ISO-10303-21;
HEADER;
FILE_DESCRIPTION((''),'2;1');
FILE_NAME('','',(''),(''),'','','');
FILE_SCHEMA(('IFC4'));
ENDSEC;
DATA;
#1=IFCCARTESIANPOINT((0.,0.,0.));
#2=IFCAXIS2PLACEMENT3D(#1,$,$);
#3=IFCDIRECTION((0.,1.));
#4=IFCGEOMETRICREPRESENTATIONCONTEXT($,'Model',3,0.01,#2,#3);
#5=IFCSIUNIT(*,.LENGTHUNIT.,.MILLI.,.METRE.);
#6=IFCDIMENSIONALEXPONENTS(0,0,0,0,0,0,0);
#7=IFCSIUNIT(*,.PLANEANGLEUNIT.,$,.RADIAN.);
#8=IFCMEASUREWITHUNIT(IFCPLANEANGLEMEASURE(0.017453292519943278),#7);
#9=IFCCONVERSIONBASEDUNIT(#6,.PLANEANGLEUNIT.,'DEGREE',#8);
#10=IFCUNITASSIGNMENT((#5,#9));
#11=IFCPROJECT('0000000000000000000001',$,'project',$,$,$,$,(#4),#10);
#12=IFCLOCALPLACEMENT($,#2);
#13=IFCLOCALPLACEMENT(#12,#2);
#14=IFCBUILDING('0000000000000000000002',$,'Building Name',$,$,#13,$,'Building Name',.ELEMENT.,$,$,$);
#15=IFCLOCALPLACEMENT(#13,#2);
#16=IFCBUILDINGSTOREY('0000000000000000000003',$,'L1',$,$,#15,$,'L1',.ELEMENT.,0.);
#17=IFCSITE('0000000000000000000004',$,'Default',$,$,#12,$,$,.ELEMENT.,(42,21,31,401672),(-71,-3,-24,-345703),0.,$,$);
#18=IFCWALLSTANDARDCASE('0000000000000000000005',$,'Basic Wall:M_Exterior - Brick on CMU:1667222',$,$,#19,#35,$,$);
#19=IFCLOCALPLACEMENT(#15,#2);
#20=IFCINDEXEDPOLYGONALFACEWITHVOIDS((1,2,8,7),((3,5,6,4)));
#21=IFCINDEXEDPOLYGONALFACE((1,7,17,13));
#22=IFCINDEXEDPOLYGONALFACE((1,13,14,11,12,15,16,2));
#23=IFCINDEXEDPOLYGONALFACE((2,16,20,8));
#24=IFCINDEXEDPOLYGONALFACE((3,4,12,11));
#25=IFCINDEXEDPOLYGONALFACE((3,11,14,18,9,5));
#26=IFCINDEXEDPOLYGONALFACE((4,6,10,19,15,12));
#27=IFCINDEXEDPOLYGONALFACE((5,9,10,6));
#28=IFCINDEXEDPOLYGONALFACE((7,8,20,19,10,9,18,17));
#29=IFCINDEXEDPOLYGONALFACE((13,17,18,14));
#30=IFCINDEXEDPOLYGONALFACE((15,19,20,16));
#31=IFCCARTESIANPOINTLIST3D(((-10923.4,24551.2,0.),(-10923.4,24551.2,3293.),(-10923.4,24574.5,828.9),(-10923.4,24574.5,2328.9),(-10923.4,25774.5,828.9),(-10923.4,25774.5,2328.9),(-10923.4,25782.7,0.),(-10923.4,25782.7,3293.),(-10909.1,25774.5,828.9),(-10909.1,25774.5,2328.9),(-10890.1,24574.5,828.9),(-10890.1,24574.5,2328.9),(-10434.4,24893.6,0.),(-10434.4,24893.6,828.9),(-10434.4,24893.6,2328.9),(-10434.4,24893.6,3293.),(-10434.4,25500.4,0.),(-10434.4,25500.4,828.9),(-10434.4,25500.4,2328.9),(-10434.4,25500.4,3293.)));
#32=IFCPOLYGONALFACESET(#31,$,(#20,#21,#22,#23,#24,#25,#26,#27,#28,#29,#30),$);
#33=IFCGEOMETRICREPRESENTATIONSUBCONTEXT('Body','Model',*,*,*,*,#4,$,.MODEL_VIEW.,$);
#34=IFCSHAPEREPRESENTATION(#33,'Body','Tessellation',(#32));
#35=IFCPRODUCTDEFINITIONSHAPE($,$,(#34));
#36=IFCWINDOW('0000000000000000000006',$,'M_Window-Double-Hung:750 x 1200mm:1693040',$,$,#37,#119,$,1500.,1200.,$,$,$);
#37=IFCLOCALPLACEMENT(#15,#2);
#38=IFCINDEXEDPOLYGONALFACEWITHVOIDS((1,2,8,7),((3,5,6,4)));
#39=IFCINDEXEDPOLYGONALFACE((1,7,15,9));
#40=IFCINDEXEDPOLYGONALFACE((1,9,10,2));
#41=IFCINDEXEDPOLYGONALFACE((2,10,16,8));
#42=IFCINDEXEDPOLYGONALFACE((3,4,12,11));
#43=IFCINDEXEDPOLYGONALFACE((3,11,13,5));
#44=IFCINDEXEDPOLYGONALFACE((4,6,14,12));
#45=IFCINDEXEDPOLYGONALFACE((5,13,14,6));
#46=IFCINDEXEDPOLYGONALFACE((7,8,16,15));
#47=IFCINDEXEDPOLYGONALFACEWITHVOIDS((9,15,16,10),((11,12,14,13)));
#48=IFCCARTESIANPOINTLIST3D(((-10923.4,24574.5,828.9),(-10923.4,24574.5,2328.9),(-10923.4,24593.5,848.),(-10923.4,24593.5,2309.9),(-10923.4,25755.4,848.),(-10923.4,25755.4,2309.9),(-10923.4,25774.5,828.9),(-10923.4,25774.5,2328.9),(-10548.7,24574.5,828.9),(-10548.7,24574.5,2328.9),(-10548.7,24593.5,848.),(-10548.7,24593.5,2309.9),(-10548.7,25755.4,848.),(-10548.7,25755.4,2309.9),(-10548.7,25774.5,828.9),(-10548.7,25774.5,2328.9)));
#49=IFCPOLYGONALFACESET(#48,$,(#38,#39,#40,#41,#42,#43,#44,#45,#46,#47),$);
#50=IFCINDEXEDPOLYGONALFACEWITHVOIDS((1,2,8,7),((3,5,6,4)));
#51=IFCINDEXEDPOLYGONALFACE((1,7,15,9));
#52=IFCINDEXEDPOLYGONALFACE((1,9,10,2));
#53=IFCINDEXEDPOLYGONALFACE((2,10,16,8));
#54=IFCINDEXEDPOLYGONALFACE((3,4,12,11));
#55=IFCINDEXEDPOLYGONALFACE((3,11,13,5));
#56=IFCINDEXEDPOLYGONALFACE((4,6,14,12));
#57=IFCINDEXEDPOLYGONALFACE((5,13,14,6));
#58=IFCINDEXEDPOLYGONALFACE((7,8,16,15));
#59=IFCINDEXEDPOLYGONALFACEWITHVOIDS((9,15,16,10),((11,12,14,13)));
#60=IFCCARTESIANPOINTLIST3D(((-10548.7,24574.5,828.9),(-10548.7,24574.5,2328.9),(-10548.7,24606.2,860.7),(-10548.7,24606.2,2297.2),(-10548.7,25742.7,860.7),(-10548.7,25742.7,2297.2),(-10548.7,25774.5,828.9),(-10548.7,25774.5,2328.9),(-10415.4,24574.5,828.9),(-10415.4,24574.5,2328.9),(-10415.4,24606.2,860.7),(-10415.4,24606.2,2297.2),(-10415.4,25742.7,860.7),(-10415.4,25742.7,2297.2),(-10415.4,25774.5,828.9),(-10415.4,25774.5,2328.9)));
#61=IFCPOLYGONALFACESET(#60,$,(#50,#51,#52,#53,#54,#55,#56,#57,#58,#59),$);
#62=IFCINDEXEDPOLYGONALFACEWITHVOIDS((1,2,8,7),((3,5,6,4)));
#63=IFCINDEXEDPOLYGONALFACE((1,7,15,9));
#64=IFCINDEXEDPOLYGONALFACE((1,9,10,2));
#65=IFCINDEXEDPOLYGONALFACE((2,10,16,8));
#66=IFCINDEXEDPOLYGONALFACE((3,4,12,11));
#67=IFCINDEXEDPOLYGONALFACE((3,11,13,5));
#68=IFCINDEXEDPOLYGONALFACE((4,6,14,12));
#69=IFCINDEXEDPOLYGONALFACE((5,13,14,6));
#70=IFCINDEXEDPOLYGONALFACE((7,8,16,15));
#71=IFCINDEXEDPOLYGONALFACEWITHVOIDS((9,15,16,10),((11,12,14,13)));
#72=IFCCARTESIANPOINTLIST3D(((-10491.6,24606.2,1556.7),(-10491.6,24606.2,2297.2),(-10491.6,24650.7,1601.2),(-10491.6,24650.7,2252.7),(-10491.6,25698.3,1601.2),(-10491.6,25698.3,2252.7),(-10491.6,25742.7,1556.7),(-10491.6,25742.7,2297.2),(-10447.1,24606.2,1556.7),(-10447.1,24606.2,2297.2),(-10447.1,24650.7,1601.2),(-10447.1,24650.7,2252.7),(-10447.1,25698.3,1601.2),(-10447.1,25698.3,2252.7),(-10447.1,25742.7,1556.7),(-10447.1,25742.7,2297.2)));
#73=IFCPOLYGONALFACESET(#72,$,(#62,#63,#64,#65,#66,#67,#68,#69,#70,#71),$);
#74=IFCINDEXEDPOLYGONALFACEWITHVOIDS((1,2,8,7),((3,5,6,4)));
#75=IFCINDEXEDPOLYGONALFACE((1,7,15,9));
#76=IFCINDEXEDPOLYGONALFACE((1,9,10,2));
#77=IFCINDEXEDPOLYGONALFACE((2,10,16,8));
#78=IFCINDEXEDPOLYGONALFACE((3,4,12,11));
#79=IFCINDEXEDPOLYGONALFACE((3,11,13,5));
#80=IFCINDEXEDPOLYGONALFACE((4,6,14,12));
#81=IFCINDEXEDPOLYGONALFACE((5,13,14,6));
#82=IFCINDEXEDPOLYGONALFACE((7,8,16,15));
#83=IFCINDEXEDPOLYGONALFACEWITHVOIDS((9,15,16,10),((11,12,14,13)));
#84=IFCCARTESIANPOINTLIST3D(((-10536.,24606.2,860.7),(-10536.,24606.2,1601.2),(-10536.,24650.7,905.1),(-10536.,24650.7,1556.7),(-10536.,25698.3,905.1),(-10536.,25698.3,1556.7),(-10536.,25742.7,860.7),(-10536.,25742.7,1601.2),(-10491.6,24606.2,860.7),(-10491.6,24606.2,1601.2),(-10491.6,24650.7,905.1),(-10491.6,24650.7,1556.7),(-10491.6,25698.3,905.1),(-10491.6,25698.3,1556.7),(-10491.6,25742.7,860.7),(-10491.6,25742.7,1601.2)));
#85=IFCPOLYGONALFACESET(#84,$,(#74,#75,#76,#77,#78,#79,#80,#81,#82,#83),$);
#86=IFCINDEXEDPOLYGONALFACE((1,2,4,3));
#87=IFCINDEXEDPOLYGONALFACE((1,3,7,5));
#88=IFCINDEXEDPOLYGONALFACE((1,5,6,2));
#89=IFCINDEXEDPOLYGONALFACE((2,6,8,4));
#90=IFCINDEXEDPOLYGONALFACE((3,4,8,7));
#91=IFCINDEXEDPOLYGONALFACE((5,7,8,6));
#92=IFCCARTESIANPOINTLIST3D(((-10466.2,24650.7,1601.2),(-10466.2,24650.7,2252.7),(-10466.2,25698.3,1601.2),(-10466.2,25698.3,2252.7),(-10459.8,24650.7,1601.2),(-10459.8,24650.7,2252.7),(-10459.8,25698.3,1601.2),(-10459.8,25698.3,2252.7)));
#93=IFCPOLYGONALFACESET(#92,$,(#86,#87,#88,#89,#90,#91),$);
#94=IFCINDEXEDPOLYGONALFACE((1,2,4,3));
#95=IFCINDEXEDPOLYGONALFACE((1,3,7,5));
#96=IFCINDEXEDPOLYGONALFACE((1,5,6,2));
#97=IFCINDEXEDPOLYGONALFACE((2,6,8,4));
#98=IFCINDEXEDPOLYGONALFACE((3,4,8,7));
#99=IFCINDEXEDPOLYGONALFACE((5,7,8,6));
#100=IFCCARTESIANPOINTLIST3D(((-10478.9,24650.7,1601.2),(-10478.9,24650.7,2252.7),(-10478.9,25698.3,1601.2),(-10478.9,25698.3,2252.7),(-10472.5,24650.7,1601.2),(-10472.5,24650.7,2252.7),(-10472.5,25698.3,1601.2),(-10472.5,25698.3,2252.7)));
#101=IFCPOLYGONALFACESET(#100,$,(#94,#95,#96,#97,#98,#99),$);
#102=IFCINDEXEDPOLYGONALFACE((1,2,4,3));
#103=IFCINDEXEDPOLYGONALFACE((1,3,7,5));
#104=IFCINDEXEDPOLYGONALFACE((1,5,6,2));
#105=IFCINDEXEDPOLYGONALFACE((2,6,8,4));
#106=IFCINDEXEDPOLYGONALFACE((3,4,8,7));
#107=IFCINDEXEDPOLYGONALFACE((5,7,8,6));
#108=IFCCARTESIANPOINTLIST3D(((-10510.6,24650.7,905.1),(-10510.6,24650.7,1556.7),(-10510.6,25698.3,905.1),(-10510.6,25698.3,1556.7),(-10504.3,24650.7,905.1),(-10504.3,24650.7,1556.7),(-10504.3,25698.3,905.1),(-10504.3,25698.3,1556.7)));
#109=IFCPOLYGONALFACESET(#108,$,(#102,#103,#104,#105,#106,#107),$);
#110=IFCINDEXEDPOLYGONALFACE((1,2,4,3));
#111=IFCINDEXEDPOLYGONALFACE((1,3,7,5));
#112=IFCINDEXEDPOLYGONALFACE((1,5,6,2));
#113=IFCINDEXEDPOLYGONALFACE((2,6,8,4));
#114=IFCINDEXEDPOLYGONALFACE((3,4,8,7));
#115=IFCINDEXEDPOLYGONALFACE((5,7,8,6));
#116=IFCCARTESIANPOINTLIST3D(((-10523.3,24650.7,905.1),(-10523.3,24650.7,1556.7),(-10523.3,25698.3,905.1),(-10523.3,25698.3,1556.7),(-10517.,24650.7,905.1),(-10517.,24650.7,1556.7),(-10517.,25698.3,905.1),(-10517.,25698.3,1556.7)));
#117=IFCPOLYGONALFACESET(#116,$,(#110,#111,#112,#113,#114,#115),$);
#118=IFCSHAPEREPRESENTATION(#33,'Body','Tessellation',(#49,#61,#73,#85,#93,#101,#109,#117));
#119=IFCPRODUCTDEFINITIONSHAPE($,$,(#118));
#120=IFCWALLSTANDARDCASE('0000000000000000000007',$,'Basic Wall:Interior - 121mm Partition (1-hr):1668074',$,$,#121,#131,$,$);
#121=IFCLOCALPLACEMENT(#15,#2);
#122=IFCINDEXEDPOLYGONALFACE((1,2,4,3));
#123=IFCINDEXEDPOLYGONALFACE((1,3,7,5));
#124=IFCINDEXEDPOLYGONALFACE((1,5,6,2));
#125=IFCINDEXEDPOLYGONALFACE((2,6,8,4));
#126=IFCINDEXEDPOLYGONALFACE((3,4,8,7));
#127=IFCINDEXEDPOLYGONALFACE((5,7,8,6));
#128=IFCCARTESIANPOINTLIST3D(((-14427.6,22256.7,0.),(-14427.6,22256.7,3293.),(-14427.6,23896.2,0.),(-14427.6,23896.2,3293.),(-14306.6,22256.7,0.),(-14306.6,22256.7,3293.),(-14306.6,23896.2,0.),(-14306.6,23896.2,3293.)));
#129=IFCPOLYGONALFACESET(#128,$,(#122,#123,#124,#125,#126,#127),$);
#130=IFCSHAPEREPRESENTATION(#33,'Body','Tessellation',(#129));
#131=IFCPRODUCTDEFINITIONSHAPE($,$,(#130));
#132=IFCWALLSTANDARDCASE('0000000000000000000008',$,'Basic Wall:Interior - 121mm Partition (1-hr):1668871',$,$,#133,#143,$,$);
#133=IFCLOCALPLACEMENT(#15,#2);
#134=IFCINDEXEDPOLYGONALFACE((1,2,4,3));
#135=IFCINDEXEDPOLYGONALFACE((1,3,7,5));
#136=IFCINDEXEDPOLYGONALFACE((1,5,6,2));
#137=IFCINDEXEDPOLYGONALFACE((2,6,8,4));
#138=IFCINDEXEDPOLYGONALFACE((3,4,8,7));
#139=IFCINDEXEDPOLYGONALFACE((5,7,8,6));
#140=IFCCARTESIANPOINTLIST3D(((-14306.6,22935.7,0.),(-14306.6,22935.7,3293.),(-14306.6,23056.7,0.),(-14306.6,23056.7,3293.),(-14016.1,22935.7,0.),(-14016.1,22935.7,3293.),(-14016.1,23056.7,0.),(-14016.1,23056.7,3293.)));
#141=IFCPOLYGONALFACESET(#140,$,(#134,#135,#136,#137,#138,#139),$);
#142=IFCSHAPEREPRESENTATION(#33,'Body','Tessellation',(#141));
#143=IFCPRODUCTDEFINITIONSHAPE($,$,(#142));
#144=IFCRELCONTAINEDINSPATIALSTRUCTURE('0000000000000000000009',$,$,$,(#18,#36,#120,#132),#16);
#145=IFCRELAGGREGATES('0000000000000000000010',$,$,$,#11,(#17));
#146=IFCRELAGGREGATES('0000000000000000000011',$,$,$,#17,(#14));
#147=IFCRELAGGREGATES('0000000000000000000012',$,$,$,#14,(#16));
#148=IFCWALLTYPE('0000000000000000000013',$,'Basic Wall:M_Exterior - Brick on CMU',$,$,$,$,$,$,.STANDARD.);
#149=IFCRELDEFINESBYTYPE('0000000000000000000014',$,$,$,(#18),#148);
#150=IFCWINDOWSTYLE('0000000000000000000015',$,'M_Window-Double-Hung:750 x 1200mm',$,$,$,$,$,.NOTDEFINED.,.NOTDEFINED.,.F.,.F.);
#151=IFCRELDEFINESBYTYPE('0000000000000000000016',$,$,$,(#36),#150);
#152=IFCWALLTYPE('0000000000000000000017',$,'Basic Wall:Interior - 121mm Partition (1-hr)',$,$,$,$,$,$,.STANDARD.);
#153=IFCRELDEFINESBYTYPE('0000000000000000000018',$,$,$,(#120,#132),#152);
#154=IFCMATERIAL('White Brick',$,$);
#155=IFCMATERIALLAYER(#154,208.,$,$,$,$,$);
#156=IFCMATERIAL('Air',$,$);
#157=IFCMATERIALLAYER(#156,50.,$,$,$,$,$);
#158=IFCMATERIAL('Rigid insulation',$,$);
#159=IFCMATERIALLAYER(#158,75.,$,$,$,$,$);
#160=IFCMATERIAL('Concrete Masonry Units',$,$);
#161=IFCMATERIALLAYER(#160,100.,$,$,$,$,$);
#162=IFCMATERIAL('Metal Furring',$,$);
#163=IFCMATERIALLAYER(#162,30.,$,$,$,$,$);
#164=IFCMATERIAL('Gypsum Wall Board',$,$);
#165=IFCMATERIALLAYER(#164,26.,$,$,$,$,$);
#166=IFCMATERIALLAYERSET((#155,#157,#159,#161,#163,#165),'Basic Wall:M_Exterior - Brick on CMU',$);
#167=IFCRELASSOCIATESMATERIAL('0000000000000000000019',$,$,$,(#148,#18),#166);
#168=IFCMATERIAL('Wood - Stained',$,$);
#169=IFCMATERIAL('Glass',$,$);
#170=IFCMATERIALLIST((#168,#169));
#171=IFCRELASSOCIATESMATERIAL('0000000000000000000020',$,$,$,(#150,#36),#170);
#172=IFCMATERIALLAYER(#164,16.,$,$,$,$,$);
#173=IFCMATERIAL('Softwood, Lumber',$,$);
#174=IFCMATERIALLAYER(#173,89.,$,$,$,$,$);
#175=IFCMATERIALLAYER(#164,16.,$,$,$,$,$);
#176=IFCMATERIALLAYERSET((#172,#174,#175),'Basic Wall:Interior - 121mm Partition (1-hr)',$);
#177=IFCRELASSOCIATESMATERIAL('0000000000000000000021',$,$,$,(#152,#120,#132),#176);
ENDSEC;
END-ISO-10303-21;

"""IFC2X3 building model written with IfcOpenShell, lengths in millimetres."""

from ifc_helpers import new_model, entity, si_unit, converted_unit, direction, frame, frame_2d, origin, place, context, subcontext, project, spatial, polyline, rectangle, outline, extrude, clip, bounded_halfspace, source, transform, mapped, material, material_list, layer, layer_set, layer_usage, type_object, type_shapes, element, fill, save


model = new_model("IFC2X3")

# Units and contexts
model_context = context("Model", 3, precision=0.01, world=origin(), true_north=direction((0.0, 1.0)))
body_context = subcontext(model_context, "Body", "Model", "MODEL_VIEW")
ifc_project = project(units=[si_unit("LENGTHUNIT", "METRE", prefix="MILLI"), converted_unit("PLANEANGLEUNIT", "DEGREE", entity("IfcPlaneAngleMeasure", 0.017453292519943278), si_unit("PLANEANGLEUNIT", "RADIAN"), dimensions=[0, 0, 0, 0, 0, 0, 0])], contexts=[model_context])

# Site, building, storey
site_placement = place(None, origin())
site = spatial("IfcSite", under=ifc_project, at=site_placement, Name="Default", CompositionType="ELEMENT", RefLatitude=(42, 21, 31, 401672), RefLongitude=(-71, -3, -24, -345703), RefElevation=0.0)
building_placement = place(site_placement, origin())
building = spatial("IfcBuilding", under=site, at=building_placement, Name="Building Name", LongName="Building Name", CompositionType="ELEMENT")
storey_placement = place(building_placement, origin())
storey = spatial("IfcBuildingStorey", under=building, at=storey_placement, Name="L1", LongName="L1", CompositionType="ELEMENT", Elevation=0.0)

# Shared definitions
ifc_material_1 = material(Name="White Brick")
ifc_layer_1 = layer(ifc_material_1, 208.0)
ifc_material_2 = material(Name="Air")
ifc_layer_2 = layer(ifc_material_2, 50.0)
ifc_material_3 = material(Name="Rigid insulation")
ifc_layer_3 = layer(ifc_material_3, 75.0)
ifc_material_4 = material(Name="Concrete Masonry Units")
ifc_layer_4 = layer(ifc_material_4, 100.0)
ifc_material_5 = material(Name="Metal Furring")
ifc_layer_5 = layer(ifc_material_5, 30.0)
ifc_material_6 = material(Name="Gypsum Wall Board")
ifc_layer_6 = layer(ifc_material_6, 26.0)
ifc_layer_set_1 = layer_set([ifc_layer_1, ifc_layer_2, ifc_layer_3, ifc_layer_4, ifc_layer_5, ifc_layer_6], Name="Basic Wall:M_Exterior - Brick on CMU")
wall_type_1 = type_object("IfcWallType", Name="Basic Wall:M_Exterior - Brick on CMU", PredefinedType="STANDARD", material=ifc_layer_set_1)
ifc_material_7 = material(Name="Wood - Stained")
ifc_material_8 = material(Name="Glass")
ifc_material_list_1 = material_list([ifc_material_7, ifc_material_8])

# Wall, opening, window
ifc_layer_usage_1 = layer_usage(ifc_layer_set_1, "AXIS2", "POSITIVE", -244.5)
wall_1_placement = place(storey_placement, frame((-10678.9, 24551.2, 0.0), z_axis=(0.0, 0.0, 1.0), x_axis=(0.0, 1.0, 0.0)))
wall_1 = element("IfcWallStandardCase", 1, at=wall_1_placement, inside=storey, type_object=wall_type_1, material=ifc_layer_usage_1, Name="Basic Wall:M_Exterior - Brick on CMU:1667222", context=body_context, shape_type="Clipping", body=[
    clip(extrude(outline(polyline([(949.2, -244.5), (1231.6, 244.5), (0.0, 244.5), (342.4, -244.5), (949.2, -244.5)])), origin(), (0.0, 0.0, 1.0), 3293.0), bounded_halfspace(frame((342.4, -244.5, 3293.0), z_axis=(0.0, 0.0, -1.0), x_axis=(-1.0, 0.0, 0.0)), True, frame((342.4, -244.5, 3293.0)), polyline([(0.0, 0.0), (606.8, 0.0), (889.2, 489.0), (-342.4, 489.0), (0.0, 0.0)]))),
])
opening_1_placement = place(wall_1_placement, frame((1223.3, 244.5, 828.9)))
opening_1 = element("IfcOpeningElement", 2, at=opening_1_placement, cuts=wall_1, ObjectType="Opening", context=body_context, shape_type="SweptSolid", body=[
    extrude(rectangle(XDim=1500.0, YDim=1200.0, at=frame_2d((750.0, 600.0), x_axis=(-1.0, 0.0))), frame((0.0, 0.0, 0.0), z_axis=(0.0, -1.0, 0.0), x_axis=(0.0, 0.0, 1.0)), (0.0, 0.0, 1.0), 489.0),
])
window_style_1 = type_object("IfcWindowStyle", Name="M_Window-Double-Hung:750 x 1200mm", ConstructionType="NOTDEFINED", OperationType="NOTDEFINED", ParameterTakesPrecedence=False, Sizeable=False, material=ifc_material_list_1)
shared_shape_1 = source(origin(), body_context, "Body", "SweptSolid", [
    extrude(outline(polyline([(-750.0, -600.0), (750.0, -600.0), (750.0, 600.0), (-750.0, 600.0), (-750.0, -600.0)]), holes=[polyline([(-730.9, -580.9), (-730.9, 580.9), (730.9, 580.9), (730.9, -580.9), (-730.9, -580.9)])]), frame((600.0, 0.0, 750.0), z_axis=(0.0, 1.0, 0.0), x_axis=(0.0, 0.0, -1.0)), (0.0, 0.0, 1.0), 374.7),
    extrude(outline(polyline([(-600.0, -750.0), (600.0, -750.0), (600.0, 750.0), (-600.0, 750.0), (-600.0, -750.0)]), holes=[polyline([(568.2, -718.2), (-568.2, -718.2), (-568.2, 718.2), (568.2, 718.2), (568.2, -718.2)])]), frame((600.0, 374.7, 750.0), z_axis=(0.0, 1.0, 0.0), x_axis=(1.0, 0.0, 0.0)), (0.0, 0.0, 1.0), 133.3),
    extrude(outline(polyline([(-568.2, -370.2), (568.2, -370.2), (568.2, 370.2), (-568.2, 370.2), (-568.2, -370.2)]), holes=[polyline([(523.8, -325.8), (-523.8, -325.8), (-523.8, 325.8), (523.8, 325.8), (523.8, -325.8)])]), frame((600.0, 431.8, 1098.0), z_axis=(0.0, 1.0, 0.0), x_axis=(1.0, 0.0, 0.0)), (0.0, 0.0, 1.0), 44.4),
    extrude(outline(polyline([(-568.2, -370.2), (568.2, -370.2), (568.2, 370.2), (-568.2, 370.2), (-568.2, -370.2)]), holes=[polyline([(523.8, -325.8), (-523.8, -325.8), (-523.8, 325.8), (523.8, 325.8), (523.8, -325.8)])]), frame((600.0, 387.4, 402.0), z_axis=(0.0, 1.0, 0.0), x_axis=(1.0, 0.0, 0.0)), (0.0, 0.0, 1.0), 44.5),
    extrude(rectangle(XDim=1047.6, YDim=6.4, at=frame_2d((0.0, 0.0), x_axis=(1.0, 0.0))), frame((600.0, 460.4, 772.2), z_axis=(0.0, 0.0, 1.0), x_axis=(-1.0, 0.0, 0.0)), (0.0, 0.0, 1.0), 651.6),
    extrude(rectangle(XDim=6.4, YDim=1047.6, at=frame_2d((0.0, 0.0), x_axis=(1.0, 0.0))), frame((600.0, 447.7, 772.2), z_axis=(0.0, 0.0, 1.0), x_axis=(0.0, -1.0, 0.0)), (0.0, 0.0, 1.0), 651.6),
    extrude(rectangle(XDim=1047.6, YDim=6.4, at=frame_2d((0.0, 0.0), x_axis=(1.0, 0.0))), frame((600.0, 416.0, 76.2), z_axis=(0.0, 0.0, 1.0), x_axis=(-1.0, 0.0, 0.0)), (0.0, 0.0, 1.0), 651.6),
    extrude(rectangle(XDim=6.4, YDim=1047.6, at=frame_2d((0.0, 0.0), x_axis=(1.0, 0.0))), frame((600.0, 403.3, 76.2), z_axis=(0.0, 0.0, 1.0), x_axis=(0.0, -1.0, 0.0)), (0.0, 0.0, 1.0), 651.6),
])
type_shapes(window_style_1, [shared_shape_1])
window_1_placement = place(opening_1_placement, frame((0.0, 0.0, 0.0), z_axis=(0.0, 0.0, 1.0), x_axis=(-1.0, 0.0, 0.0)))
window_1 = element("IfcWindow", 3, at=window_1_placement, inside=storey, type_object=window_style_1, material=ifc_material_list_1, Name="M_Window-Double-Hung:750 x 1200mm:1693040", OverallHeight=1500.0, OverallWidth=1200.0, context=body_context, shape_type="MappedRepresentation", body=[
    mapped(shared_shape_1, transform((0.0, 0.0, 0.0), scale=1.0)),
])
fill(opening_1, window_1)

# Walls
ifc_layer_7 = layer(ifc_material_6, 16.0)
ifc_material_9 = material(Name="Softwood, Lumber")
ifc_layer_8 = layer(ifc_material_9, 89.0)
ifc_layer_9 = layer(ifc_material_6, 16.0)
ifc_layer_set_2 = layer_set([ifc_layer_7, ifc_layer_8, ifc_layer_9], Name="Basic Wall:Interior - 121mm Partition (1-hr)")
ifc_layer_usage_2 = layer_usage(ifc_layer_set_2, "AXIS2", "NEGATIVE", 60.5)
wall_type_2 = type_object("IfcWallType", Name="Basic Wall:Interior - 121mm Partition (1-hr)", PredefinedType="STANDARD", material=ifc_layer_set_2)
wall_2_placement = place(storey_placement, frame((-14367.1, 23896.2, 0.0), z_axis=(0.0, 0.0, 1.0), x_axis=(0.0, -1.0, 0.0)))
element("IfcWallStandardCase", 4, at=wall_2_placement, inside=storey, type_object=wall_type_2, material=ifc_layer_usage_2, Name="Basic Wall:Interior - 121mm Partition (1-hr):1668074", context=body_context, shape_type="Clipping", body=[
    clip(extrude(rectangle(XDim=1639.5, YDim=121.0, at=frame_2d((819.7, 0.0), x_axis=(-1.0, 0.0))), origin(), (0.0, 0.0, 1.0), 3293.0), bounded_halfspace(frame((0.0, -60.5, 3293.0), z_axis=(0.0, 0.0, -1.0), x_axis=(1.0, 0.0, 0.0)), True, frame((0.0, -60.5, 3293.0)), polyline([(0.0, 0.0), (1639.5, 0.0), (1639.5, 121.0), (960.5, 121.0), (839.5, 121.0), (0.0, 121.0), (0.0, 0.0)]))),
])
ifc_layer_usage_3 = layer_usage(ifc_layer_set_2, "AXIS2", "NEGATIVE", 60.5)
wall_3_placement = place(storey_placement, frame((-14306.6, 22996.2, 0.0)))
element("IfcWallStandardCase", 5, at=wall_3_placement, inside=storey, type_object=wall_type_2, material=ifc_layer_usage_3, Name="Basic Wall:Interior - 121mm Partition (1-hr):1668871", context=body_context, shape_type="Clipping", body=[
    clip(extrude(rectangle(XDim=290.5, YDim=121.0, at=frame_2d((145.2, 0.0), x_axis=(-1.0, 0.0))), origin(), (0.0, 0.0, 1.0), 3293.0), bounded_halfspace(frame((0.0, -60.5, 3293.0), z_axis=(0.0, 0.0, -1.0), x_axis=(0.0, -1.0, 0.0)), True, frame((0.0, -60.5, 3293.0)), polyline([(0.0, 0.0), (290.5, 0.0), (290.5, 121.0), (0.0, 121.0), (0.0, 0.0)]))),
])

save(model, "model.ifc")
